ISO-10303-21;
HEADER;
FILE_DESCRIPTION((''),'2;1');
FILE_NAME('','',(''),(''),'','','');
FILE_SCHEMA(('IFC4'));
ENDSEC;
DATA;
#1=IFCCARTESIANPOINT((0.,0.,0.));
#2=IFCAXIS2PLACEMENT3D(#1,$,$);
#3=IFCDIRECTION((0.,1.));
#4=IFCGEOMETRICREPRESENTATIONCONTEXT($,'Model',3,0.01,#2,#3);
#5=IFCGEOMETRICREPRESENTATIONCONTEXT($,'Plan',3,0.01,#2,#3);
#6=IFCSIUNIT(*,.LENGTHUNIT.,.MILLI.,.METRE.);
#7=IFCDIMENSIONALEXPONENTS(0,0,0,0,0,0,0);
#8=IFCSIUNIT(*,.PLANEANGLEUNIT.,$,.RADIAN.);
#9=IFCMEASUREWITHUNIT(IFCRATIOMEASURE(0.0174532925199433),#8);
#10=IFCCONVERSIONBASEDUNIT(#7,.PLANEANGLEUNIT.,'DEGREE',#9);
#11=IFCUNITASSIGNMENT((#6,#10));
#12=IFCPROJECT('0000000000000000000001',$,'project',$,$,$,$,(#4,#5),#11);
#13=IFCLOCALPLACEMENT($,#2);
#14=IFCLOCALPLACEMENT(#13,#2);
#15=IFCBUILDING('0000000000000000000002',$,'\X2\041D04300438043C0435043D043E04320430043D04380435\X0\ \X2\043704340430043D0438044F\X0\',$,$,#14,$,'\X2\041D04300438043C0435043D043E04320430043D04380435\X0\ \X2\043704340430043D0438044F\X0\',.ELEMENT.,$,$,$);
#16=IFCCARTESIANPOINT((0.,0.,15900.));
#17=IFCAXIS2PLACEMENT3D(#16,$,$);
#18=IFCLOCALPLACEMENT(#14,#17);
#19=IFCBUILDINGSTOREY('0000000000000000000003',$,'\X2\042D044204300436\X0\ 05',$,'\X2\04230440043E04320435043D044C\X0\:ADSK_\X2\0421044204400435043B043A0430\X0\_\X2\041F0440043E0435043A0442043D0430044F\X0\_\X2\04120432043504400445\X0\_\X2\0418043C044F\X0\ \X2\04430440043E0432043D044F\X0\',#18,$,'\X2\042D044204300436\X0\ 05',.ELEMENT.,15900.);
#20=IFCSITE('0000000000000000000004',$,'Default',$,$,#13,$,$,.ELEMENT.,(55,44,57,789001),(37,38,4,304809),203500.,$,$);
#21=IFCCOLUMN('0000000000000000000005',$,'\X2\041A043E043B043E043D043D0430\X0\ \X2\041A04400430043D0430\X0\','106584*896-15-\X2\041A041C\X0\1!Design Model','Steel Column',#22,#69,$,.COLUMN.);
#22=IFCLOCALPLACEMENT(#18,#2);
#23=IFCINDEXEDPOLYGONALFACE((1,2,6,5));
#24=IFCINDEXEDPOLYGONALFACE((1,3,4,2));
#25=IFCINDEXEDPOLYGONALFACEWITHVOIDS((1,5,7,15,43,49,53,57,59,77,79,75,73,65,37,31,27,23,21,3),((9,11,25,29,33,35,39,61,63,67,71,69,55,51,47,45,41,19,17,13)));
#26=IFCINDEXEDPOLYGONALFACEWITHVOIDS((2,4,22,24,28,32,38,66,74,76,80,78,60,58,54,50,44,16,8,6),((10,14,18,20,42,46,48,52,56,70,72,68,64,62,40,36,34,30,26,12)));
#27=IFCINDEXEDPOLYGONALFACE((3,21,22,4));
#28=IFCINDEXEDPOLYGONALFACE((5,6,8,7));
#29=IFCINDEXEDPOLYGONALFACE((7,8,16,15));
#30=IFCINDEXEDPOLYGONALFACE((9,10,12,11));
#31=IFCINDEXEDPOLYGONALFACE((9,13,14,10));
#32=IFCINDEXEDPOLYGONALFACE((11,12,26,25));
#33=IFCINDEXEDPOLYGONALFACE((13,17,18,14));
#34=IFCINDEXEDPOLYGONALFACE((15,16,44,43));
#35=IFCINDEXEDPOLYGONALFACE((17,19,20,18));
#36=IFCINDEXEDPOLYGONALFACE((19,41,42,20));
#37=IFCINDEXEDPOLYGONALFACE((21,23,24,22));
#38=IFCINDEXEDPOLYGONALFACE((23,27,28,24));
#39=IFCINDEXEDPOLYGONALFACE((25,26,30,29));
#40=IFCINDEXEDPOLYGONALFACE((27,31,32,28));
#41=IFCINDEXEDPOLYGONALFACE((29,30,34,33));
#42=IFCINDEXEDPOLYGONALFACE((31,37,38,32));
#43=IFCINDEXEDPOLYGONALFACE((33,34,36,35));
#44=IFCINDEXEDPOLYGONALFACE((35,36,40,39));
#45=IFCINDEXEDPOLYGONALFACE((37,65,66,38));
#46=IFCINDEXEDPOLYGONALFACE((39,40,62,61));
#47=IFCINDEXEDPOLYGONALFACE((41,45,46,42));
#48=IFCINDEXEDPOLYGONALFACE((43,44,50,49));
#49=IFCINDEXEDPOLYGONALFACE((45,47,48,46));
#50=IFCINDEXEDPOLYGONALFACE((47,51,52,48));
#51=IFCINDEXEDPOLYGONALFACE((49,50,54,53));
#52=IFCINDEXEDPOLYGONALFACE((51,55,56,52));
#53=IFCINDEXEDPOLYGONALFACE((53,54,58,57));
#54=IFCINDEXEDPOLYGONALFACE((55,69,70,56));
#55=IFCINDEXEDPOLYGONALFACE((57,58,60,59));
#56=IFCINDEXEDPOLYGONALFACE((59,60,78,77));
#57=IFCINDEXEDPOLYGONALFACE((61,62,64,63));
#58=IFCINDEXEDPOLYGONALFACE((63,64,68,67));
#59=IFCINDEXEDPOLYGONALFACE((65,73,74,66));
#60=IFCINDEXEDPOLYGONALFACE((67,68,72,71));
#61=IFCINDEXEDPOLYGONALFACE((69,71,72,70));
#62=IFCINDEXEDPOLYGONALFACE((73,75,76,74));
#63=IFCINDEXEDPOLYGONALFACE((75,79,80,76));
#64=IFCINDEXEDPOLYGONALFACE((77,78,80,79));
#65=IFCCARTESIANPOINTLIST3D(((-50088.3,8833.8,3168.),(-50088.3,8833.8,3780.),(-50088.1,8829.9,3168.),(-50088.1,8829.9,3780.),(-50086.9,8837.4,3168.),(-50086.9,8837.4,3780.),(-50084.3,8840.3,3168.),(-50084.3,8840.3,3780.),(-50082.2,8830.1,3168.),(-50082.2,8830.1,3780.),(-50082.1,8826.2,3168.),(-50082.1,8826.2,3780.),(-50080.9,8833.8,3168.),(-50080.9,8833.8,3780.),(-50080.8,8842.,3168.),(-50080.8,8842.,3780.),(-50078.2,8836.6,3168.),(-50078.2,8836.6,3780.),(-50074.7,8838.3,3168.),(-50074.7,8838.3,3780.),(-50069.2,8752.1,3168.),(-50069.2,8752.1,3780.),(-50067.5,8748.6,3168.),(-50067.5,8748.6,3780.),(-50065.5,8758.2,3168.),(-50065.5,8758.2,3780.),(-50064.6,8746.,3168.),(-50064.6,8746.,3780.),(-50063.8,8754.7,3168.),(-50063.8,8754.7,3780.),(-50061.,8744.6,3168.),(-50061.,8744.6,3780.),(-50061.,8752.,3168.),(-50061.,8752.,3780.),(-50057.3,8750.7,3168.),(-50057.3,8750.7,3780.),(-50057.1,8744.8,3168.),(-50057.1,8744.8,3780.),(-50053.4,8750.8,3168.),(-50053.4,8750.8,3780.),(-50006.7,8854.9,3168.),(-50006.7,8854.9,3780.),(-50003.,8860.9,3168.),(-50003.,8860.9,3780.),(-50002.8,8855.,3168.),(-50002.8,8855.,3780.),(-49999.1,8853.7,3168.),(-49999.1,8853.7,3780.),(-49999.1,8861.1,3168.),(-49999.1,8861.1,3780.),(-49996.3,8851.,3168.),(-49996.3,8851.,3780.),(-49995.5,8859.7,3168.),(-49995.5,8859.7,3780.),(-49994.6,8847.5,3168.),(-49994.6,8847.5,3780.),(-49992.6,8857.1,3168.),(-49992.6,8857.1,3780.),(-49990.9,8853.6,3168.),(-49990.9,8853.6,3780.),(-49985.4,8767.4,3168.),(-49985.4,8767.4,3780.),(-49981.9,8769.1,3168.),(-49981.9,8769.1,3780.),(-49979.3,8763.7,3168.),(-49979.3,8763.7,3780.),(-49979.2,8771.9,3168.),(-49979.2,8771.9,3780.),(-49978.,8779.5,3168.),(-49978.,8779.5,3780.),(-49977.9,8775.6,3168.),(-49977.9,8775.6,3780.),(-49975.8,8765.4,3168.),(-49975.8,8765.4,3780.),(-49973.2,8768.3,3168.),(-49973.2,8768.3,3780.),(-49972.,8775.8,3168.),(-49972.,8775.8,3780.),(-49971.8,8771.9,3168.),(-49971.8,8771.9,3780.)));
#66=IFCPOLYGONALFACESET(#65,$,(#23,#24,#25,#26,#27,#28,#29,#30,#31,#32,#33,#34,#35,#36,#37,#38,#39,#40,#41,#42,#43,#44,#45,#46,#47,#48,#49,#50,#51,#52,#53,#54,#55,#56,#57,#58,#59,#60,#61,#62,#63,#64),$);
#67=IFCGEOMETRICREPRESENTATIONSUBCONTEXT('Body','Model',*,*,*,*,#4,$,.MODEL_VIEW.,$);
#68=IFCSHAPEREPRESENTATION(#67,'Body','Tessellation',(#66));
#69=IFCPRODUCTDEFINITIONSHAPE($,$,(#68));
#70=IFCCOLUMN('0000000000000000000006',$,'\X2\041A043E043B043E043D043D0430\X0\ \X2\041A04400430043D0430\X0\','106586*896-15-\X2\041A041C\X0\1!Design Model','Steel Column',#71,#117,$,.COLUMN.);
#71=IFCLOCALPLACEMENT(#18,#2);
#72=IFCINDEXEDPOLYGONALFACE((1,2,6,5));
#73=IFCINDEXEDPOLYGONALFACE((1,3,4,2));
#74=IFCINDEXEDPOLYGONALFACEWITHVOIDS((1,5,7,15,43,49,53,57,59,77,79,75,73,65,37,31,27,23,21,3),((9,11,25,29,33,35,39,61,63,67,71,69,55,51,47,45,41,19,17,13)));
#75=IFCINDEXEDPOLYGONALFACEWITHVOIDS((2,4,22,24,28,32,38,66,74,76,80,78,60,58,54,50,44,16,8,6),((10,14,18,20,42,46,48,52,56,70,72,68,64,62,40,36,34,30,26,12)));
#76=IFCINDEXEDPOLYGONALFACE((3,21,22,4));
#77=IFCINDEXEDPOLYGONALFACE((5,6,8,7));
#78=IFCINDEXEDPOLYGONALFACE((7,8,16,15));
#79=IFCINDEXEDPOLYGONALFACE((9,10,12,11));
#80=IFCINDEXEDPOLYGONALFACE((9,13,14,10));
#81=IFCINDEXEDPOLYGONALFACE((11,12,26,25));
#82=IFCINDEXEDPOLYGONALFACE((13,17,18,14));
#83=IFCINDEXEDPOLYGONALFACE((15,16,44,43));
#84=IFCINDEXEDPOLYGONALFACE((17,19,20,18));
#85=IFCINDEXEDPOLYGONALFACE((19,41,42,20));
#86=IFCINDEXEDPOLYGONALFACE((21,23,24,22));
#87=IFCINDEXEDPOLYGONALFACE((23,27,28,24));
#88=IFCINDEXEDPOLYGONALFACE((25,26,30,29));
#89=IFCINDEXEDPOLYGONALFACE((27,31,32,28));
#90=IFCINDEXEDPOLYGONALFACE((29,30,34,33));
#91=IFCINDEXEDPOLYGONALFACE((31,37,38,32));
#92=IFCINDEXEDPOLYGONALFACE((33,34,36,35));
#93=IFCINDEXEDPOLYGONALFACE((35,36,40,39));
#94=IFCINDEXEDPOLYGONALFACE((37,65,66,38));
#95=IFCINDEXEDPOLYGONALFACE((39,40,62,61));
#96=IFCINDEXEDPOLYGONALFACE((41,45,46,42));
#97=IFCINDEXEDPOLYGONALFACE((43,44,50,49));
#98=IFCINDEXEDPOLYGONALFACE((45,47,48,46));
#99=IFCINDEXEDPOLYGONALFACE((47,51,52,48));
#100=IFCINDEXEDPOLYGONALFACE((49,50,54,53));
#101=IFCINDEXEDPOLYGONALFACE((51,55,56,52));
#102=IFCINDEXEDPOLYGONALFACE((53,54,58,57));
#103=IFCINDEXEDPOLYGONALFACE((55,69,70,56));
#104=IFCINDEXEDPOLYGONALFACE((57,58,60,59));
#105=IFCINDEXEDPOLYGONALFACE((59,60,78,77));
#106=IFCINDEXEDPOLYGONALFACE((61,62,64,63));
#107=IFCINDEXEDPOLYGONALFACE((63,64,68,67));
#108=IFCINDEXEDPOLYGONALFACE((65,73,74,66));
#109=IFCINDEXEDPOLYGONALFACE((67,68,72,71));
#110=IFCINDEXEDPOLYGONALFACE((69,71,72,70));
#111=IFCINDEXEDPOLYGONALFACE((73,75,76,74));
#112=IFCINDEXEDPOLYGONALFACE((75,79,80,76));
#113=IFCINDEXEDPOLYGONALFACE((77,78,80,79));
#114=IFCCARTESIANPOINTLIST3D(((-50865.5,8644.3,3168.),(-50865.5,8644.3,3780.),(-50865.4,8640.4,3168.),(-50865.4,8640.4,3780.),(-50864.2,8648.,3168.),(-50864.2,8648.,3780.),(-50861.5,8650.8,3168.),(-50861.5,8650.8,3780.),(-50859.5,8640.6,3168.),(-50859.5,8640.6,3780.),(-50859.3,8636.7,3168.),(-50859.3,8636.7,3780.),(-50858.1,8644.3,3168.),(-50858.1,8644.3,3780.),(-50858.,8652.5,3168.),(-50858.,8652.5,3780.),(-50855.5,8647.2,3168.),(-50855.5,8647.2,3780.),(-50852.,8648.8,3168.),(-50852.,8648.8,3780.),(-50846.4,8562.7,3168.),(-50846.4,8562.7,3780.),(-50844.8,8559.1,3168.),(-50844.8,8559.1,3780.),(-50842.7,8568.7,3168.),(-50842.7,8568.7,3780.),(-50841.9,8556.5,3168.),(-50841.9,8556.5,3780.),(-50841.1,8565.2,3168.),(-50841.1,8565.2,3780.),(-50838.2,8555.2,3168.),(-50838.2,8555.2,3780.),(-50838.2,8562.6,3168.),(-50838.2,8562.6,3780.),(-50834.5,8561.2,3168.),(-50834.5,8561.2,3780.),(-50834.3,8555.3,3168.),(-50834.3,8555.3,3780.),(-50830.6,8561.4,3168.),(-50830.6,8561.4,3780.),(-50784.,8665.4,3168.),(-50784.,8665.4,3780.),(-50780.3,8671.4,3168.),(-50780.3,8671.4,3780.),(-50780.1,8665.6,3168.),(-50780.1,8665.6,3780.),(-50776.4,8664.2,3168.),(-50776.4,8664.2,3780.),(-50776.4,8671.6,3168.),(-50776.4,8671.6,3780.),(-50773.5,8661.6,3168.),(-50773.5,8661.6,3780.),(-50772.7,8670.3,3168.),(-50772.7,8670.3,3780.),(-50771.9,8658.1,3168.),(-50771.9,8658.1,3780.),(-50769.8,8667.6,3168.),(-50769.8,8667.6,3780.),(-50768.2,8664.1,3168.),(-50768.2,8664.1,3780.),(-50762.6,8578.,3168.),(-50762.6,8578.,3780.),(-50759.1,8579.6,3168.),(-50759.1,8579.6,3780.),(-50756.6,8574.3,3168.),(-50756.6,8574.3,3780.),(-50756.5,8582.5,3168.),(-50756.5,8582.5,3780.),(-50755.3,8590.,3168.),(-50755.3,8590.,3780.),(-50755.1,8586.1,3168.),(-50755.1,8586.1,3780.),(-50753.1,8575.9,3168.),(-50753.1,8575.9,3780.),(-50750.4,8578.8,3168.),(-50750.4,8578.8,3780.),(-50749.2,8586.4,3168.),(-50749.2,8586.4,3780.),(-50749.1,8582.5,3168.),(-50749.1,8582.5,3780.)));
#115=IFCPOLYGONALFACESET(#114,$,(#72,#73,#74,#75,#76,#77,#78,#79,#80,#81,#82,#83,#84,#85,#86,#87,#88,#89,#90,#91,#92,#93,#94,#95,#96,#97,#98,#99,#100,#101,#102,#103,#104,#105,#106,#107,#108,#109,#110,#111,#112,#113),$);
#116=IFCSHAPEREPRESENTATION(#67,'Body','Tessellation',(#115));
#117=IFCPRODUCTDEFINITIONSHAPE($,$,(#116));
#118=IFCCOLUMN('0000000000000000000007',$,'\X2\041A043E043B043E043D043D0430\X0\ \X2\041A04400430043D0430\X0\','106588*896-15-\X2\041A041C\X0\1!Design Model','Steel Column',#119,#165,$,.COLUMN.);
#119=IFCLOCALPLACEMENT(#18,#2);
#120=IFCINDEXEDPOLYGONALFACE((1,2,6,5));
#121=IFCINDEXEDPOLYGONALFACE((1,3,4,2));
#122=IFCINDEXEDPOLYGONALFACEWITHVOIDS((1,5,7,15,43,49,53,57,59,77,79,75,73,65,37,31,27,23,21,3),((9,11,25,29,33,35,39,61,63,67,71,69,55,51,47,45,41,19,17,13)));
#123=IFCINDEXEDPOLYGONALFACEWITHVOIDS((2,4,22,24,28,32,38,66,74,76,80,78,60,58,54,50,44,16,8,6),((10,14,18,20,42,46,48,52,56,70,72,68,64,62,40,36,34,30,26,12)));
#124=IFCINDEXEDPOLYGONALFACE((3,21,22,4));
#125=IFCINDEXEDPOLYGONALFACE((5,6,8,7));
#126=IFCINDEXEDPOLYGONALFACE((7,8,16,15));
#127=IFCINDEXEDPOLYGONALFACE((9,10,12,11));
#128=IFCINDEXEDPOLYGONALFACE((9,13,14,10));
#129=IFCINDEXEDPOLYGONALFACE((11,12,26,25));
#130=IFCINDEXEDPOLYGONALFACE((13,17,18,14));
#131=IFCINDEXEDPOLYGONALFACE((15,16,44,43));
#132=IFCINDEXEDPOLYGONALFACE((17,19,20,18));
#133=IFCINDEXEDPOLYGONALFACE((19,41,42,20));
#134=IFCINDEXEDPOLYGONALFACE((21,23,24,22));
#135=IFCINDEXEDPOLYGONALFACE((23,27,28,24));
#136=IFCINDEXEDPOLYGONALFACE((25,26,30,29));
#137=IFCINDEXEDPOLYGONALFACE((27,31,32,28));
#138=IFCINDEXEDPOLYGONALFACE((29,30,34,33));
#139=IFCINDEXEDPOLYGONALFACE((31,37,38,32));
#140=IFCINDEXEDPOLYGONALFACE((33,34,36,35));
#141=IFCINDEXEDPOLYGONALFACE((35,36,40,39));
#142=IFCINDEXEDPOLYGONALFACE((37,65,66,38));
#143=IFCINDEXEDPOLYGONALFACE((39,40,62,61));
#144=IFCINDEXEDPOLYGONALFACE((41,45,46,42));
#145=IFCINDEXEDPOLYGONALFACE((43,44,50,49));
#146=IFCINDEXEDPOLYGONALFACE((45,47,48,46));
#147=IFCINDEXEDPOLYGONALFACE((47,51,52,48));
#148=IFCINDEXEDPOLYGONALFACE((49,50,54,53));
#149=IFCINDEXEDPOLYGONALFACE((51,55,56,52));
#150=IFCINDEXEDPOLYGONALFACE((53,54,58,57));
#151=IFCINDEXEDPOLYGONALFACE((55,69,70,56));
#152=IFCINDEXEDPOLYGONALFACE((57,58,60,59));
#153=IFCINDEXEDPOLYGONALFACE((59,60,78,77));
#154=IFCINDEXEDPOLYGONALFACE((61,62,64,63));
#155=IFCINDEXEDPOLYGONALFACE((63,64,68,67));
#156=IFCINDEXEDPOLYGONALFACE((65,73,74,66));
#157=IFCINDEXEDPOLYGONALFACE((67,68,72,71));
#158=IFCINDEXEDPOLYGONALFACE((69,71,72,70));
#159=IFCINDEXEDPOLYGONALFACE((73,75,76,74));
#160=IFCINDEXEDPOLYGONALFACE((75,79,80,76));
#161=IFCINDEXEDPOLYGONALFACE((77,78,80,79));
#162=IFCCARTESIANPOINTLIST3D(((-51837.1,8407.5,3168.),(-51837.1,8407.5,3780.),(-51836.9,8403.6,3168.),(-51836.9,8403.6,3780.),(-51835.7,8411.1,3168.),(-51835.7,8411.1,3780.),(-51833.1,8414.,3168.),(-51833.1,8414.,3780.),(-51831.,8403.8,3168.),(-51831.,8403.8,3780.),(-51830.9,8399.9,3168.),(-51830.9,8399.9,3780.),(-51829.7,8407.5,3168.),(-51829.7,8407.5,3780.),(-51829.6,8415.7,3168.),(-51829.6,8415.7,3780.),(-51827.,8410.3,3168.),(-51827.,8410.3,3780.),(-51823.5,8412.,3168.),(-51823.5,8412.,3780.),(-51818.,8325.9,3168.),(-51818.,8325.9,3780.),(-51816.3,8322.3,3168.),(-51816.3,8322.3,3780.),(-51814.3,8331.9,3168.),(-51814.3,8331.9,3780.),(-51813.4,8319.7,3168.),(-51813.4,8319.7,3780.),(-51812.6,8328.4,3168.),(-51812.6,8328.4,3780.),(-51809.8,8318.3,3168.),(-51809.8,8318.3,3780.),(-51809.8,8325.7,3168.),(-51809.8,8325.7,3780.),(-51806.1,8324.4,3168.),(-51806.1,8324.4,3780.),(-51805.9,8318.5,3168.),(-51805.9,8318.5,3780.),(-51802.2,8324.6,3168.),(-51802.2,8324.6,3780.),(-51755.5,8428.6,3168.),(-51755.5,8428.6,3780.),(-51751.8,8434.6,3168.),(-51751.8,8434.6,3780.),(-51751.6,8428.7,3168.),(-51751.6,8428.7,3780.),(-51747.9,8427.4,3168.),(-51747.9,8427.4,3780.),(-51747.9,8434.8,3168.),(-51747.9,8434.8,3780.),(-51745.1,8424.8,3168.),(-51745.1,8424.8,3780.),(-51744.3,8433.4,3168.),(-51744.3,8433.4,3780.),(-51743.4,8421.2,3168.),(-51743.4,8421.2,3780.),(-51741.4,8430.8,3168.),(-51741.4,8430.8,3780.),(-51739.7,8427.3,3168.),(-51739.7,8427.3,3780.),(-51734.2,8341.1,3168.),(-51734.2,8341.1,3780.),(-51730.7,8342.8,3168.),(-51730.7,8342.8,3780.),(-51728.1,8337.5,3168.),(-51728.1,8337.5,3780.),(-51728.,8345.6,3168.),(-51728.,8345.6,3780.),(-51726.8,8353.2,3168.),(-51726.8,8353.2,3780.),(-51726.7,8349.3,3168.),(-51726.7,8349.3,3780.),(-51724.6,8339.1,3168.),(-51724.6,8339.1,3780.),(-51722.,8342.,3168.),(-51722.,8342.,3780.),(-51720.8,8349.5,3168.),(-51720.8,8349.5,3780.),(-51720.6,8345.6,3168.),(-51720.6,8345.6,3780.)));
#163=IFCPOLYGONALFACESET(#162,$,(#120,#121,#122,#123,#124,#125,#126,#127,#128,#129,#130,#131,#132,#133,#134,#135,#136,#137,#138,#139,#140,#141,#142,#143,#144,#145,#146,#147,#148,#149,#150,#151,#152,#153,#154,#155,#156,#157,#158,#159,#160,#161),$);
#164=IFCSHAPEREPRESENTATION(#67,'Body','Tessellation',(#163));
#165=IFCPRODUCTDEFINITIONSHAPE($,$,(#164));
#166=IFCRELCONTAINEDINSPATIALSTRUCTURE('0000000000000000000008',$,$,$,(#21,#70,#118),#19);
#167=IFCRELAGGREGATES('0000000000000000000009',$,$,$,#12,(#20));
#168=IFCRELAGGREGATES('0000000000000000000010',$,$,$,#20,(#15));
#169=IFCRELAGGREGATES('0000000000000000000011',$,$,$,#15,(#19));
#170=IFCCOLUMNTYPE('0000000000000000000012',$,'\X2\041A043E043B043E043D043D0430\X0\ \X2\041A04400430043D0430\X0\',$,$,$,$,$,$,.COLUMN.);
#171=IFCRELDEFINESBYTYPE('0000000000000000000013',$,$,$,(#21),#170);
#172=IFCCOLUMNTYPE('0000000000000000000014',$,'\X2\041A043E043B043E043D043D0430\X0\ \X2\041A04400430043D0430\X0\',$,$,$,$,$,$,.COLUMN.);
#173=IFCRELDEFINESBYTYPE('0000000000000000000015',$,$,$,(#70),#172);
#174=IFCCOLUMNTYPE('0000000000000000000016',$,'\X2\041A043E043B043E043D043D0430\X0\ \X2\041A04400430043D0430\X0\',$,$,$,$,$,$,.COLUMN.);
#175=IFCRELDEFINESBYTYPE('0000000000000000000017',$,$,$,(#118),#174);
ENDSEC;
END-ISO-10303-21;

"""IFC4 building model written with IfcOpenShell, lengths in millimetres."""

from ifc_helpers import new_model, entity, si_unit, converted_unit, direction, frame, origin, place, context, subcontext, project, spatial, indexed_curve, outline, extrude, type_object, element, save


model = new_model("IFC4")

# Units and contexts
model_context = context("Model", 3, precision=0.01, world=origin(), true_north=direction((0.0, 1.0)))
plan_context = context("Plan", 3, precision=0.01, world=origin(), true_north=direction((0.0, 1.0)))
body_context = subcontext(model_context, "Body", "Model", "MODEL_VIEW")
ifc_project = project(units=[si_unit("LENGTHUNIT", "METRE", prefix="MILLI"), converted_unit("PLANEANGLEUNIT", "DEGREE", entity("IfcRatioMeasure", 0.0174532925199433), si_unit("PLANEANGLEUNIT", "RADIAN"), dimensions=[0, 0, 0, 0, 0, 0, 0])], contexts=[model_context, plan_context])

# Site, building, storey
site_placement = place(None, origin())
site = spatial("IfcSite", under=ifc_project, at=site_placement, Name="Default", CompositionType="ELEMENT", RefLatitude=(55, 44, 57, 789001), RefLongitude=(37, 38, 4, 304809), RefElevation=203500.0)
building_placement = place(site_placement, origin())
building = spatial("IfcBuilding", under=site, at=building_placement, Name="Наименование здания", LongName="Наименование здания", CompositionType="ELEMENT")
storey_placement = place(building_placement, frame((0.0, 0.0, 15900.0)))
storey = spatial("IfcBuildingStorey", under=building, at=storey_placement, Name="Этаж 05", ObjectType="Уровень:ADSK_Стрелка_Проектная_Вверх_Имя уровня", LongName="Этаж 05", CompositionType="ELEMENT", Elevation=15900.0)

# Columns
placement = place(storey_placement, origin())
column_type_1 = type_object("IfcColumnType", Name="Колонна Крана", PredefinedType="COLUMN")
element("IfcColumn", 1, at=placement, inside=storey, type_object=column_type_1, Name="Колонна Крана", Description="106584*896-15-КМ1!Design Model", ObjectType="Steel Column", PredefinedType="COLUMN", context=body_context, shape_type="SweptSolid", body=[
    extrude(outline(indexed_curve([(29.5, -56.8), (33.4, -56.8), (37.0, -55.3), (39.7, -52.6), (41.2, -49.0), (56.8, 29.5), (56.8, 33.4), (55.3, 37.0), (52.6, 39.7), (49.0, 41.2), (-29.5, 56.8), (-33.4, 56.8), (-37.0, 55.3), (-39.7, 52.6), (-41.2, 49.0), (-56.8, -29.5), (-56.8, -33.4), (-55.3, -37.0), (-52.6, -39.7), (-49.0, -41.2), (29.5, -56.8)], self_intersect=False), holes=[indexed_curve([(-43.1, -37.3), (-46.7, -35.8), (-49.5, -33.1), (-51.0, -29.5), (-51.0, -25.5), (-37.3, 43.1), (-35.8, 46.7), (-33.1, 49.5), (-29.5, 51.0), (-25.5, 51.0), (43.1, 37.3), (46.7, 35.8), (49.5, 33.1), (51.0, 29.5), (51.0, 25.5), (37.3, -43.1), (35.8, -46.7), (33.1, -49.5), (29.5, -51.0), (25.5, -51.0), (-43.1, -37.3)], self_intersect=False)]), frame((-50030.1, 8802.9, 3168.0), z_axis=(0.0, 0.0, 1.0), x_axis=(0.906681, 0.421816, 0.0)), (0.0, 0.0, 1.0), 612.0),
])
column_type_2 = type_object("IfcColumnType", Name="Колонна Крана", PredefinedType="COLUMN")
element("IfcColumn", 2, at=placement, inside=storey, type_object=column_type_2, Name="Колонна Крана", Description="106586*896-15-КМ1!Design Model", ObjectType="Steel Column", PredefinedType="COLUMN", context=body_context, shape_type="SweptSolid", body=[
    extrude(outline(indexed_curve([(29.5, -56.8), (33.4, -56.8), (37.0, -55.3), (39.7, -52.6), (41.2, -49.0), (56.8, 29.5), (56.8, 33.4), (55.3, 37.0), (52.6, 39.7), (49.0, 41.2), (-29.5, 56.8), (-33.4, 56.8), (-37.0, 55.3), (-39.7, 52.6), (-41.2, 49.0), (-56.8, -29.5), (-56.8, -33.4), (-55.3, -37.0), (-52.6, -39.7), (-49.0, -41.2), (29.5, -56.8)], self_intersect=False), holes=[indexed_curve([(-43.1, -37.3), (-46.7, -35.8), (-49.5, -33.1), (-51.0, -29.5), (-51.0, -25.5), (-37.3, 43.1), (-35.8, 46.7), (-33.1, 49.5), (-29.5, 51.0), (-25.5, 51.0), (43.1, 37.3), (46.7, 35.8), (49.5, 33.1), (51.0, 29.5), (51.0, 25.5), (37.3, -43.1), (35.8, -46.7), (33.1, -49.5), (29.5, -51.0), (25.5, -51.0), (-43.1, -37.3)], self_intersect=False)]), frame((-50807.3, 8613.4, 3168.0), z_axis=(0.0, 0.0, 1.0), x_axis=(0.906681, 0.421816, 0.0)), (0.0, 0.0, 1.0), 612.0),
])
column_type_3 = type_object("IfcColumnType", Name="Колонна Крана", PredefinedType="COLUMN")
element("IfcColumn", 3, at=placement, inside=storey, type_object=column_type_3, Name="Колонна Крана", Description="106588*896-15-КМ1!Design Model", ObjectType="Steel Column", PredefinedType="COLUMN", context=body_context, shape_type="SweptSolid", body=[
    extrude(outline(indexed_curve([(29.5, -56.8), (33.4, -56.8), (37.0, -55.3), (39.7, -52.6), (41.2, -49.0), (56.8, 29.5), (56.8, 33.4), (55.3, 37.0), (52.6, 39.7), (49.0, 41.2), (-29.5, 56.8), (-33.4, 56.8), (-37.0, 55.3), (-39.7, 52.6), (-41.2, 49.0), (-56.8, -29.5), (-56.8, -33.4), (-55.3, -37.0), (-52.6, -39.7), (-49.0, -41.2), (29.5, -56.8)], self_intersect=False), holes=[indexed_curve([(-43.1, -37.3), (-46.7, -35.8), (-49.5, -33.1), (-51.0, -29.5), (-51.0, -25.5), (-37.3, 43.1), (-35.8, 46.7), (-33.1, 49.5), (-29.5, 51.0), (-25.5, 51.0), (43.1, 37.3), (46.7, 35.8), (49.5, 33.1), (51.0, 29.5), (51.0, 25.5), (37.3, -43.1), (35.8, -46.7), (33.1, -49.5), (29.5, -51.0), (25.5, -51.0), (-43.1, -37.3)], self_intersect=False)]), frame((-51778.8, 8376.6, 3168.0), z_axis=(0.0, 0.0, 1.0), x_axis=(0.906681, 0.421816, 0.0)), (0.0, 0.0, 1.0), 612.0),
])

save(model, "model.ifc")
